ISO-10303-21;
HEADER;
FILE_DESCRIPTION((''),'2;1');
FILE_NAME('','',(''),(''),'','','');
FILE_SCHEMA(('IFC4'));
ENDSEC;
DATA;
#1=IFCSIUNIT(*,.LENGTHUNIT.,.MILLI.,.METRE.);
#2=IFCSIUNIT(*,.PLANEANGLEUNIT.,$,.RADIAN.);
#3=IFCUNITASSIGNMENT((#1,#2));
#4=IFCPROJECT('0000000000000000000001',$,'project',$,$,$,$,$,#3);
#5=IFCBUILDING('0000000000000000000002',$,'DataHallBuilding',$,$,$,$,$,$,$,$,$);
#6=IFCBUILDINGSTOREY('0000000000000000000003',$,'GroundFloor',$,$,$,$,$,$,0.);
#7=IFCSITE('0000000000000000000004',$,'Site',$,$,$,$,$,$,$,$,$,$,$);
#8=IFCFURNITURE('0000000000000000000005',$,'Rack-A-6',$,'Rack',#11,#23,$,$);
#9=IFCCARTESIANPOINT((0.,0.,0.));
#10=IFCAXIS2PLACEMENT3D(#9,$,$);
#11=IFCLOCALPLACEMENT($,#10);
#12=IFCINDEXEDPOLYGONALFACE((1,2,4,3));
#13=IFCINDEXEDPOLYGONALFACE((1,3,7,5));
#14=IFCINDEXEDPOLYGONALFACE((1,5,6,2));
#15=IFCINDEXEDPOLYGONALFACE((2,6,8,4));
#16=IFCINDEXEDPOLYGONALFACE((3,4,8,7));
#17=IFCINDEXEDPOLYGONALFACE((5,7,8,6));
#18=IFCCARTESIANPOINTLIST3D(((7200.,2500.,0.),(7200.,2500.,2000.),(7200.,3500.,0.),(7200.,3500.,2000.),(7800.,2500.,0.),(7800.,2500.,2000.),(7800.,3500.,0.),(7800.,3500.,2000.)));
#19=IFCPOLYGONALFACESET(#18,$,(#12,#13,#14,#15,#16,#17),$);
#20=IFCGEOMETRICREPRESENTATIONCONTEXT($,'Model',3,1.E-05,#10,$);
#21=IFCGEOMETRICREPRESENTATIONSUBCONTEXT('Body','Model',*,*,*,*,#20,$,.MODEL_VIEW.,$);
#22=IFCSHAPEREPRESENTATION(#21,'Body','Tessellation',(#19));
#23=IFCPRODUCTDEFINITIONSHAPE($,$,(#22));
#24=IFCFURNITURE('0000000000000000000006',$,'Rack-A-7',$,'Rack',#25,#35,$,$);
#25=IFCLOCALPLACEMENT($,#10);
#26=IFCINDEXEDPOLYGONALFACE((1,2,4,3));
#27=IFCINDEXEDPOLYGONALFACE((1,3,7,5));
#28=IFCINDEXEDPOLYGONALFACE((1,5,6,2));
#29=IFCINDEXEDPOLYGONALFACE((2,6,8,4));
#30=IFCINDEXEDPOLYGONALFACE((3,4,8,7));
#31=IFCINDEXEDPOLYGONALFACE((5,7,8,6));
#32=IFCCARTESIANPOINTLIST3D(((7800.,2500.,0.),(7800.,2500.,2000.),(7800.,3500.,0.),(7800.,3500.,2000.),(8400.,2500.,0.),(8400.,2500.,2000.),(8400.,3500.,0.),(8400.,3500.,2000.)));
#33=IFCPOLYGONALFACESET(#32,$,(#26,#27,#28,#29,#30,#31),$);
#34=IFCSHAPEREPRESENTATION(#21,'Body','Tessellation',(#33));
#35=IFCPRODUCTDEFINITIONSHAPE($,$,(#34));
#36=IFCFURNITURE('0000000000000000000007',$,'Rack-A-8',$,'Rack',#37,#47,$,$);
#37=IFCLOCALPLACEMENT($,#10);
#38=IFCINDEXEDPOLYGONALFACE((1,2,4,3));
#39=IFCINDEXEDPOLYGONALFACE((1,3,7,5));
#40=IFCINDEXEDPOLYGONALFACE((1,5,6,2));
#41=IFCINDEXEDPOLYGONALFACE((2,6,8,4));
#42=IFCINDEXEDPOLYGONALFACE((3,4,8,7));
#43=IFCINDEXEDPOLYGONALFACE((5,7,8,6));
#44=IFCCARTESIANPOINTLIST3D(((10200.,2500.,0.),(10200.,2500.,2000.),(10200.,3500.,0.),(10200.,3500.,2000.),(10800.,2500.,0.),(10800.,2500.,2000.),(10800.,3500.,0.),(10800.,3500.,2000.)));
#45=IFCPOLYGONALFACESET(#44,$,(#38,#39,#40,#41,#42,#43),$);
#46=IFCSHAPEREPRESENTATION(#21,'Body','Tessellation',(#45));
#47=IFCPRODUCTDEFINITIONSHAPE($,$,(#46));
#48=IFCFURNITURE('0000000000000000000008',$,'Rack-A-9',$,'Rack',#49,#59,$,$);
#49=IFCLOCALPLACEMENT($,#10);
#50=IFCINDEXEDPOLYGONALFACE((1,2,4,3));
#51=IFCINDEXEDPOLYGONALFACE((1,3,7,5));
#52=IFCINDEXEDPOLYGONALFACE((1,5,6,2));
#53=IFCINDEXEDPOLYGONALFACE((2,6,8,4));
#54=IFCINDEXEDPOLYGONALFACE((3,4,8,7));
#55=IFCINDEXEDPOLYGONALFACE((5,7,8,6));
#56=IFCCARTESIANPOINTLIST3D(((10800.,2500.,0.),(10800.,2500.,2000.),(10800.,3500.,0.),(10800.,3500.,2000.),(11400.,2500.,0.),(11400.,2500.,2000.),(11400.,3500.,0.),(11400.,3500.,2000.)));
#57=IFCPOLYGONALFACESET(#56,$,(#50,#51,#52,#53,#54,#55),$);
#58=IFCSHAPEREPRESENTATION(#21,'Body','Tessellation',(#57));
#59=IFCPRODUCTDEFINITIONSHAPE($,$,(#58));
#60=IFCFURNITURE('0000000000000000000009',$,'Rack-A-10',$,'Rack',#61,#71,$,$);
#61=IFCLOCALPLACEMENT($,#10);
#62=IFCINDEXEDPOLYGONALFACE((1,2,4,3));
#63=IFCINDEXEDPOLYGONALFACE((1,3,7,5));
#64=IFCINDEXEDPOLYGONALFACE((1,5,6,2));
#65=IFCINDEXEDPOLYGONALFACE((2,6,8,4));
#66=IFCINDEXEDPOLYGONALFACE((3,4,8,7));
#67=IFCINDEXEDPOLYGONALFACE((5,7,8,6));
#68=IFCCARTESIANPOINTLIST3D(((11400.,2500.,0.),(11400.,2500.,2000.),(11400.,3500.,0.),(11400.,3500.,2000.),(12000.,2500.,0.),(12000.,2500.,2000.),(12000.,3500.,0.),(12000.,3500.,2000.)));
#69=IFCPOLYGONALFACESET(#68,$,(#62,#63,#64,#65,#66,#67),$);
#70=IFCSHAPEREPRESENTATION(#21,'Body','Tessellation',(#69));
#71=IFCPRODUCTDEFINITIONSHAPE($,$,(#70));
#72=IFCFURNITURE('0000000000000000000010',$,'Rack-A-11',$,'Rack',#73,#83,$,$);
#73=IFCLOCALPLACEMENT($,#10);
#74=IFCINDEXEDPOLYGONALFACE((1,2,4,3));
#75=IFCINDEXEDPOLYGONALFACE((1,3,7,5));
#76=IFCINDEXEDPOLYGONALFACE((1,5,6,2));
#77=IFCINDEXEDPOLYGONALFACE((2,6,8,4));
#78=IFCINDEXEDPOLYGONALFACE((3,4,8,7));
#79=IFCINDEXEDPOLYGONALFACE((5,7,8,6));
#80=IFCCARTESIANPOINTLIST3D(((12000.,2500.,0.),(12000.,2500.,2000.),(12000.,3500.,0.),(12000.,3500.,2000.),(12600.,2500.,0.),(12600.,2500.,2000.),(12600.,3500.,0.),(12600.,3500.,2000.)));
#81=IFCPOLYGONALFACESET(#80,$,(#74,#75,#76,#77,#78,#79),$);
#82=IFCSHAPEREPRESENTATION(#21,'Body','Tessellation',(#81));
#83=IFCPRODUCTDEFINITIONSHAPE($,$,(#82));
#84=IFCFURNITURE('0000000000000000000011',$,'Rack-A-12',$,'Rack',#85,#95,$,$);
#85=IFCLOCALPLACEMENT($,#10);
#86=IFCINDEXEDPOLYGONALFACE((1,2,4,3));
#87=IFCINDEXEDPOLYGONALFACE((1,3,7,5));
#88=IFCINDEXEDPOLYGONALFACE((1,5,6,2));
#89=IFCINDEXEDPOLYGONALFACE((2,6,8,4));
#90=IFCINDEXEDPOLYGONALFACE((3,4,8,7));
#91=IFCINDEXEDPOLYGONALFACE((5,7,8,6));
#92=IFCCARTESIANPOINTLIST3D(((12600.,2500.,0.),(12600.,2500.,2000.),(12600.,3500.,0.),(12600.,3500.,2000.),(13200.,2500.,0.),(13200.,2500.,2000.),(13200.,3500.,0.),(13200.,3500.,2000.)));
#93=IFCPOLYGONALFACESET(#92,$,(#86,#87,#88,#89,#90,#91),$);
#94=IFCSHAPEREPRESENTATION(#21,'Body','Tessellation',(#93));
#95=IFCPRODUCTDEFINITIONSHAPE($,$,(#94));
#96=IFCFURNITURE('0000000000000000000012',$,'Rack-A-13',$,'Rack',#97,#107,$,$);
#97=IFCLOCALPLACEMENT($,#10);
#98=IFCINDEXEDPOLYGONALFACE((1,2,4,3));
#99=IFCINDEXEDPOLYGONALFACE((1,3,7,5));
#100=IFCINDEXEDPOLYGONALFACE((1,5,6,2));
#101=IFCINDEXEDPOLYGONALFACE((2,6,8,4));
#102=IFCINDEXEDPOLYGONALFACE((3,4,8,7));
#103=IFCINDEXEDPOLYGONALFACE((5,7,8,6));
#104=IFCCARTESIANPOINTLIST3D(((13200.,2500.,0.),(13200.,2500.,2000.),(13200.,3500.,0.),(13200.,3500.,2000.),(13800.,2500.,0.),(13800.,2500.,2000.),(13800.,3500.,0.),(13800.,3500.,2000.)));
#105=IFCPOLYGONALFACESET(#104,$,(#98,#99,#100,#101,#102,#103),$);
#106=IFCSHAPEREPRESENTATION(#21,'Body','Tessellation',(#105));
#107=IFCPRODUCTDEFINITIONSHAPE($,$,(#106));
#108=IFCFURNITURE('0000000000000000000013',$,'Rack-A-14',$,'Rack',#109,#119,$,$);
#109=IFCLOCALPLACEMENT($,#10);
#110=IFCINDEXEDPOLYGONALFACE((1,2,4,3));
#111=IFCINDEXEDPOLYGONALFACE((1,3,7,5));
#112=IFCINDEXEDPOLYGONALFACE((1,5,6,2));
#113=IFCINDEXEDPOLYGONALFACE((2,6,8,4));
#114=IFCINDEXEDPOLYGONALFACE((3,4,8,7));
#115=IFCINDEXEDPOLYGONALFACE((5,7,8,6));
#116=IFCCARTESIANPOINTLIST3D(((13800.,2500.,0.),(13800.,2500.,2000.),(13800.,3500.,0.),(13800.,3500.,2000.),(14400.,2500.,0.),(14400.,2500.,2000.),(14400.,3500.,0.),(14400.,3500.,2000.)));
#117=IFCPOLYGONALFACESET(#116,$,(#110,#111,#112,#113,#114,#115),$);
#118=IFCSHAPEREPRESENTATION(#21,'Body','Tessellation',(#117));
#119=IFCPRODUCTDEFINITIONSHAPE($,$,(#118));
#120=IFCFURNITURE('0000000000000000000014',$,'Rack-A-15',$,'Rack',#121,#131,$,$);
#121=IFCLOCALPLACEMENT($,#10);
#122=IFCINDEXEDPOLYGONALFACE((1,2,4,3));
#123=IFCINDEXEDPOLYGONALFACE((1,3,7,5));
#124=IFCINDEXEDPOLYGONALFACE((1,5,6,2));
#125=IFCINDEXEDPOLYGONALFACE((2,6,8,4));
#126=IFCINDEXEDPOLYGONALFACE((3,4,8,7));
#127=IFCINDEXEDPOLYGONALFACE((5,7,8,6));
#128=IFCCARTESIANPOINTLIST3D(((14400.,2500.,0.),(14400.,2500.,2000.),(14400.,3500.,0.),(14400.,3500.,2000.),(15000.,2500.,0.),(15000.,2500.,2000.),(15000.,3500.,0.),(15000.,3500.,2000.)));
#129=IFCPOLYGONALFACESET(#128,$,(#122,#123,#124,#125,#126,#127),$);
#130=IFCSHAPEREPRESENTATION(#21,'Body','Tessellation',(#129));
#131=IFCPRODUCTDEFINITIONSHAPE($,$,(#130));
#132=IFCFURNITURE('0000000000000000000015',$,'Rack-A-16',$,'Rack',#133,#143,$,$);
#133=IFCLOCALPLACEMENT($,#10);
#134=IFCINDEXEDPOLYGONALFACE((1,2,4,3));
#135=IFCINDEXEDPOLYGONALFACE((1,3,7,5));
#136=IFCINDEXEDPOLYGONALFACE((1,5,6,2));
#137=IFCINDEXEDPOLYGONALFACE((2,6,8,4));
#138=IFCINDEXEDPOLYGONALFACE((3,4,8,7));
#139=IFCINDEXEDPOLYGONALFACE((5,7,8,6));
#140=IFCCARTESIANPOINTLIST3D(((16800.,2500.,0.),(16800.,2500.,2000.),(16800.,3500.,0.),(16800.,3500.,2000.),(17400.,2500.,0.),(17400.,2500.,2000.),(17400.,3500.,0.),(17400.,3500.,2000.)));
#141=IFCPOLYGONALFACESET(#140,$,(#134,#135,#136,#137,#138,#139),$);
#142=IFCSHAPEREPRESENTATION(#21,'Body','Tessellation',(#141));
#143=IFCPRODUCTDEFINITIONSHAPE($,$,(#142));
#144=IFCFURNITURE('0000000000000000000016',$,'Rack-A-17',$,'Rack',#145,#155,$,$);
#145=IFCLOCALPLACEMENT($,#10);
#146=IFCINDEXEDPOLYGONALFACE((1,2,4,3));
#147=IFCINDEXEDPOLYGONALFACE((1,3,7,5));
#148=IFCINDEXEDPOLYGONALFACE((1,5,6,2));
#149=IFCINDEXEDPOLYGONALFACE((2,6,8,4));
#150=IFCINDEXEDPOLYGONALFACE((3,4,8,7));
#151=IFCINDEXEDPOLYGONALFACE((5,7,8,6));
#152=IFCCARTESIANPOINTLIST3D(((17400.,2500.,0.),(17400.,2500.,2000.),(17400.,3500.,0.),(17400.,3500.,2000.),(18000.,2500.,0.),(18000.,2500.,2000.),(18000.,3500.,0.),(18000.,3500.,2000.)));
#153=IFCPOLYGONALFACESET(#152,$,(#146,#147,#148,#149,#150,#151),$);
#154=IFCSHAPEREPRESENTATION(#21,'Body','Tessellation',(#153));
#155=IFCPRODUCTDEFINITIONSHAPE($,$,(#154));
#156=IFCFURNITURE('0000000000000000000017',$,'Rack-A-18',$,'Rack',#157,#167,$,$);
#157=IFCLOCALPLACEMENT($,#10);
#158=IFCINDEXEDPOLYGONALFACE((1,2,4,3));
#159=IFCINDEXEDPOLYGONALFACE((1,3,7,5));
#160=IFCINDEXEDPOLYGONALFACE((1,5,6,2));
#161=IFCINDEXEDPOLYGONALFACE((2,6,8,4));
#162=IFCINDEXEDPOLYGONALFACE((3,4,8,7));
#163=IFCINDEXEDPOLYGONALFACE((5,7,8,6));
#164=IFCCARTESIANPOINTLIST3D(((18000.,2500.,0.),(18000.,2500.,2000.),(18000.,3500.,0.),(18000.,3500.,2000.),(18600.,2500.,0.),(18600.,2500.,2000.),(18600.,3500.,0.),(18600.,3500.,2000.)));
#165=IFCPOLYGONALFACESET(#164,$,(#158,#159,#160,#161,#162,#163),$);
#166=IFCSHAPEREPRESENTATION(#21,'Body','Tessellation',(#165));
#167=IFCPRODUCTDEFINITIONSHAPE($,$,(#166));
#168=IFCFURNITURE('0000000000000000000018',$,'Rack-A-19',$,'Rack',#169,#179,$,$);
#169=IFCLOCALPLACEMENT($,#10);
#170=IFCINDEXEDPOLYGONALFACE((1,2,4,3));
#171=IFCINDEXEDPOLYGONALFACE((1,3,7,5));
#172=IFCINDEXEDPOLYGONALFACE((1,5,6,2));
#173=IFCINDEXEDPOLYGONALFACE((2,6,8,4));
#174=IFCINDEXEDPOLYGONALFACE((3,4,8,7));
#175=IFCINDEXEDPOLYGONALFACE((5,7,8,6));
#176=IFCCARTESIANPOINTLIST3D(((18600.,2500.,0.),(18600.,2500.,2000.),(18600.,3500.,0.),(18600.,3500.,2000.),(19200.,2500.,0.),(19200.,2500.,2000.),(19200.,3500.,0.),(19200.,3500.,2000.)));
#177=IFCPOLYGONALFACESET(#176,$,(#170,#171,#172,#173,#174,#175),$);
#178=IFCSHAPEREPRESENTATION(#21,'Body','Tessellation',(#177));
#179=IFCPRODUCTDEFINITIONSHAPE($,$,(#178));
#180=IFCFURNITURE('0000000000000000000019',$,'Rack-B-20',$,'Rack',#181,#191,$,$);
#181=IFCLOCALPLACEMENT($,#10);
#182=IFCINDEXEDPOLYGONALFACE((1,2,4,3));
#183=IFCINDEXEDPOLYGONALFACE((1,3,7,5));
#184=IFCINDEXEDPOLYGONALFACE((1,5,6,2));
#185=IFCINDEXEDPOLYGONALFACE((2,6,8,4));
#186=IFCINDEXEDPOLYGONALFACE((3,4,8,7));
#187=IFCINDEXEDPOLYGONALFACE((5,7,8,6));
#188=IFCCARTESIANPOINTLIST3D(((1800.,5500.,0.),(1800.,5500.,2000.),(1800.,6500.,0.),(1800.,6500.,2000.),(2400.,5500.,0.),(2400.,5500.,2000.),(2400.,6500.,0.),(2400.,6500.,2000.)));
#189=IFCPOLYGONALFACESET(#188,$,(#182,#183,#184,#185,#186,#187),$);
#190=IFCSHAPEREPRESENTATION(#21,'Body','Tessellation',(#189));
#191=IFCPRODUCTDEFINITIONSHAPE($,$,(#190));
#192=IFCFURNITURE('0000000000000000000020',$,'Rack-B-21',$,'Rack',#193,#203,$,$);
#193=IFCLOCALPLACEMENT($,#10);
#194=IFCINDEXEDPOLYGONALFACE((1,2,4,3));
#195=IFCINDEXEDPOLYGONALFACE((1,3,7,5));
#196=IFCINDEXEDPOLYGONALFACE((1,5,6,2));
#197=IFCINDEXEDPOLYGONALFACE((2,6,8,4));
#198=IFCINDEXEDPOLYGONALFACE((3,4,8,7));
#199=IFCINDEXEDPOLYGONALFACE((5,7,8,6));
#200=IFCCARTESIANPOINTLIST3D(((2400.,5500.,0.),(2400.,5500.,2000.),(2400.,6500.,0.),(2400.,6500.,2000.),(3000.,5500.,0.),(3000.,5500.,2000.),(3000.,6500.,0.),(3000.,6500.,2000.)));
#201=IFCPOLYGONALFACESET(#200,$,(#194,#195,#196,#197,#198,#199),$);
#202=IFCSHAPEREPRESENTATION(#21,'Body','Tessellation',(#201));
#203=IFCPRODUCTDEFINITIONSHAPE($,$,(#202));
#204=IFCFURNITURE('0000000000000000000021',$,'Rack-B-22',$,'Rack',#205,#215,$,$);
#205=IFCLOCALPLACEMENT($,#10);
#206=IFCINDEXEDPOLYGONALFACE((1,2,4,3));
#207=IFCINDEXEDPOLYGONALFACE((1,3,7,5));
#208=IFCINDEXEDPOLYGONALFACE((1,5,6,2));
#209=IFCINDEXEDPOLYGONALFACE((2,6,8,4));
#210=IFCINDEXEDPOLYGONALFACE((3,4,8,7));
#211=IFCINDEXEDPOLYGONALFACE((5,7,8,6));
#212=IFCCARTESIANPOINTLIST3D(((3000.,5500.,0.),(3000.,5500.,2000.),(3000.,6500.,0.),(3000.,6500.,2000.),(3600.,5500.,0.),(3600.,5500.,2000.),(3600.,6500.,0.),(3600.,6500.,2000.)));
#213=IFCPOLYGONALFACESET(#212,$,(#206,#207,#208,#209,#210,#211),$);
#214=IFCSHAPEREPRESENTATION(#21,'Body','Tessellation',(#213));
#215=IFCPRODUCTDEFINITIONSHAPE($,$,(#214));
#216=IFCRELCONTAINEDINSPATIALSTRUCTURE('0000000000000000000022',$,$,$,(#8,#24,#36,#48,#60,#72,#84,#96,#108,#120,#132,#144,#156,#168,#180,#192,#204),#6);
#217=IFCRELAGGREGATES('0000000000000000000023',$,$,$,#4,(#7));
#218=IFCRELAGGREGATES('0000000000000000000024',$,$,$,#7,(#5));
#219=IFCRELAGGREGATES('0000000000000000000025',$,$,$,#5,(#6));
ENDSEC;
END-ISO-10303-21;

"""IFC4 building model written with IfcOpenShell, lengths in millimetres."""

from ifc_helpers import new_model, si_unit, frame, origin, place, context, subcontext, project, spatial, rectangle, extrude, element, save


model = new_model("IFC4")

# Units and contexts
model_context = context("Model", 3, precision=1e-05, world=origin())
body_context = subcontext(model_context, "Body", "Model", "MODEL_VIEW")
ifc_project = project(units=[si_unit("LENGTHUNIT", "METRE", prefix="MILLI"), si_unit("PLANEANGLEUNIT", "RADIAN")])

# Site, building, storey
site = spatial("IfcSite", under=ifc_project, Name="Site")
building = spatial("IfcBuilding", under=site, Name="DataHallBuilding")
storey = spatial("IfcBuildingStorey", under=building, Name="GroundFloor", Elevation=0.0)

# Furniture
furniture_1_placement = place(None, origin())
element("IfcFurniture", 1, at=furniture_1_placement, inside=storey, Name="Rack-A-6", ObjectType="Rack", context=body_context, shape_type="SweptSolid", body=[
    extrude(rectangle(XDim=600.0, YDim=1000.0), frame((7500.0, 3000.0, 0.0), z_axis=(0.0, 0.0, 1.0), x_axis=(1.0, 0.0, 0.0)), (0.0, 0.0, 1.0), 2000.0),
])
furniture_2_placement = place(None, origin())
element("IfcFurniture", 2, at=furniture_2_placement, inside=storey, Name="Rack-A-7", ObjectType="Rack", context=body_context, shape_type="SweptSolid", body=[
    extrude(rectangle(XDim=600.0, YDim=1000.0), frame((8100.0, 3000.0, 0.0), z_axis=(0.0, 0.0, 1.0), x_axis=(1.0, 0.0, 0.0)), (0.0, 0.0, 1.0), 2000.0),
])
furniture_3_placement = place(None, origin())
element("IfcFurniture", 3, at=furniture_3_placement, inside=storey, Name="Rack-A-8", ObjectType="Rack", context=body_context, shape_type="SweptSolid", body=[
    extrude(rectangle(XDim=600.0, YDim=1000.0), frame((10500.0, 3000.0, 0.0), z_axis=(0.0, 0.0, 1.0), x_axis=(1.0, 0.0, 0.0)), (0.0, 0.0, 1.0), 2000.0),
])
furniture_4_placement = place(None, origin())
element("IfcFurniture", 4, at=furniture_4_placement, inside=storey, Name="Rack-A-9", ObjectType="Rack", context=body_context, shape_type="SweptSolid", body=[
    extrude(rectangle(XDim=600.0, YDim=1000.0), frame((11100.0, 3000.0, 0.0), z_axis=(0.0, 0.0, 1.0), x_axis=(1.0, 0.0, 0.0)), (0.0, 0.0, 1.0), 2000.0),
])
furniture_5_placement = place(None, origin())
element("IfcFurniture", 5, at=furniture_5_placement, inside=storey, Name="Rack-A-10", ObjectType="Rack", context=body_context, shape_type="SweptSolid", body=[
    extrude(rectangle(XDim=600.0, YDim=1000.0), frame((11700.0, 3000.0, 0.0), z_axis=(0.0, 0.0, 1.0), x_axis=(1.0, 0.0, 0.0)), (0.0, 0.0, 1.0), 2000.0),
])
furniture_6_placement = place(None, origin())
element("IfcFurniture", 6, at=furniture_6_placement, inside=storey, Name="Rack-A-11", ObjectType="Rack", context=body_context, shape_type="SweptSolid", body=[
    extrude(rectangle(XDim=600.0, YDim=1000.0), frame((12300.0, 3000.0, 0.0), z_axis=(0.0, 0.0, 1.0), x_axis=(1.0, 0.0, 0.0)), (0.0, 0.0, 1.0), 2000.0),
])
furniture_7_placement = place(None, origin())
element("IfcFurniture", 7, at=furniture_7_placement, inside=storey, Name="Rack-A-12", ObjectType="Rack", context=body_context, shape_type="SweptSolid", body=[
    extrude(rectangle(XDim=600.0, YDim=1000.0), frame((12900.0, 3000.0, 0.0), z_axis=(0.0, 0.0, 1.0), x_axis=(1.0, 0.0, 0.0)), (0.0, 0.0, 1.0), 2000.0),
])
furniture_8_placement = place(None, origin())
element("IfcFurniture", 8, at=furniture_8_placement, inside=storey, Name="Rack-A-13", ObjectType="Rack", context=body_context, shape_type="SweptSolid", body=[
    extrude(rectangle(XDim=600.0, YDim=1000.0), frame((13500.0, 3000.0, 0.0), z_axis=(0.0, 0.0, 1.0), x_axis=(1.0, 0.0, 0.0)), (0.0, 0.0, 1.0), 2000.0),
])
furniture_9_placement = place(None, origin())
element("IfcFurniture", 9, at=furniture_9_placement, inside=storey, Name="Rack-A-14", ObjectType="Rack", context=body_context, shape_type="SweptSolid", body=[
    extrude(rectangle(XDim=600.0, YDim=1000.0), frame((14100.0, 3000.0, 0.0), z_axis=(0.0, 0.0, 1.0), x_axis=(1.0, 0.0, 0.0)), (0.0, 0.0, 1.0), 2000.0),
])
furniture_10_placement = place(None, origin())
element("IfcFurniture", 10, at=furniture_10_placement, inside=storey, Name="Rack-A-15", ObjectType="Rack", context=body_context, shape_type="SweptSolid", body=[
    extrude(rectangle(XDim=600.0, YDim=1000.0), frame((14700.0, 3000.0, 0.0), z_axis=(0.0, 0.0, 1.0), x_axis=(1.0, 0.0, 0.0)), (0.0, 0.0, 1.0), 2000.0),
])
furniture_11_placement = place(None, origin())
element("IfcFurniture", 11, at=furniture_11_placement, inside=storey, Name="Rack-A-16", ObjectType="Rack", context=body_context, shape_type="SweptSolid", body=[
    extrude(rectangle(XDim=600.0, YDim=1000.0), frame((17100.0, 3000.0, 0.0), z_axis=(0.0, 0.0, 1.0), x_axis=(1.0, 0.0, 0.0)), (0.0, 0.0, 1.0), 2000.0),
])
furniture_12_placement = place(None, origin())
element("IfcFurniture", 12, at=furniture_12_placement, inside=storey, Name="Rack-A-17", ObjectType="Rack", context=body_context, shape_type="SweptSolid", body=[
    extrude(rectangle(XDim=600.0, YDim=1000.0), frame((17700.0, 3000.0, 0.0), z_axis=(0.0, 0.0, 1.0), x_axis=(1.0, 0.0, 0.0)), (0.0, 0.0, 1.0), 2000.0),
])
furniture_13_placement = place(None, origin())
element("IfcFurniture", 13, at=furniture_13_placement, inside=storey, Name="Rack-A-18", ObjectType="Rack", context=body_context, shape_type="SweptSolid", body=[
    extrude(rectangle(XDim=600.0, YDim=1000.0), frame((18300.0, 3000.0, 0.0), z_axis=(0.0, 0.0, 1.0), x_axis=(1.0, 0.0, 0.0)), (0.0, 0.0, 1.0), 2000.0),
])
furniture_14_placement = place(None, origin())
element("IfcFurniture", 14, at=furniture_14_placement, inside=storey, Name="Rack-A-19", ObjectType="Rack", context=body_context, shape_type="SweptSolid", body=[
    extrude(rectangle(XDim=600.0, YDim=1000.0), frame((18900.0, 3000.0, 0.0), z_axis=(0.0, 0.0, 1.0), x_axis=(1.0, 0.0, 0.0)), (0.0, 0.0, 1.0), 2000.0),
])
furniture_15_placement = place(None, origin())
element("IfcFurniture", 15, at=furniture_15_placement, inside=storey, Name="Rack-B-20", ObjectType="Rack", context=body_context, shape_type="SweptSolid", body=[
    extrude(rectangle(XDim=600.0, YDim=1000.0), frame((2100.0, 6000.0, 0.0), z_axis=(0.0, 0.0, 1.0), x_axis=(1.0, 0.0, 0.0)), (0.0, 0.0, 1.0), 2000.0),
])
furniture_16_placement = place(None, origin())
element("IfcFurniture", 16, at=furniture_16_placement, inside=storey, Name="Rack-B-21", ObjectType="Rack", context=body_context, shape_type="SweptSolid", body=[
    extrude(rectangle(XDim=600.0, YDim=1000.0), frame((2700.0, 6000.0, 0.0), z_axis=(0.0, 0.0, 1.0), x_axis=(1.0, 0.0, 0.0)), (0.0, 0.0, 1.0), 2000.0),
])
furniture_17_placement = place(None, origin())
element("IfcFurniture", 17, at=furniture_17_placement, inside=storey, Name="Rack-B-22", ObjectType="Rack", context=body_context, shape_type="SweptSolid", body=[
    extrude(rectangle(XDim=600.0, YDim=1000.0), frame((3300.0, 6000.0, 0.0), z_axis=(0.0, 0.0, 1.0), x_axis=(1.0, 0.0, 0.0)), (0.0, 0.0, 1.0), 2000.0),
])

save(model, "model.ifc")
